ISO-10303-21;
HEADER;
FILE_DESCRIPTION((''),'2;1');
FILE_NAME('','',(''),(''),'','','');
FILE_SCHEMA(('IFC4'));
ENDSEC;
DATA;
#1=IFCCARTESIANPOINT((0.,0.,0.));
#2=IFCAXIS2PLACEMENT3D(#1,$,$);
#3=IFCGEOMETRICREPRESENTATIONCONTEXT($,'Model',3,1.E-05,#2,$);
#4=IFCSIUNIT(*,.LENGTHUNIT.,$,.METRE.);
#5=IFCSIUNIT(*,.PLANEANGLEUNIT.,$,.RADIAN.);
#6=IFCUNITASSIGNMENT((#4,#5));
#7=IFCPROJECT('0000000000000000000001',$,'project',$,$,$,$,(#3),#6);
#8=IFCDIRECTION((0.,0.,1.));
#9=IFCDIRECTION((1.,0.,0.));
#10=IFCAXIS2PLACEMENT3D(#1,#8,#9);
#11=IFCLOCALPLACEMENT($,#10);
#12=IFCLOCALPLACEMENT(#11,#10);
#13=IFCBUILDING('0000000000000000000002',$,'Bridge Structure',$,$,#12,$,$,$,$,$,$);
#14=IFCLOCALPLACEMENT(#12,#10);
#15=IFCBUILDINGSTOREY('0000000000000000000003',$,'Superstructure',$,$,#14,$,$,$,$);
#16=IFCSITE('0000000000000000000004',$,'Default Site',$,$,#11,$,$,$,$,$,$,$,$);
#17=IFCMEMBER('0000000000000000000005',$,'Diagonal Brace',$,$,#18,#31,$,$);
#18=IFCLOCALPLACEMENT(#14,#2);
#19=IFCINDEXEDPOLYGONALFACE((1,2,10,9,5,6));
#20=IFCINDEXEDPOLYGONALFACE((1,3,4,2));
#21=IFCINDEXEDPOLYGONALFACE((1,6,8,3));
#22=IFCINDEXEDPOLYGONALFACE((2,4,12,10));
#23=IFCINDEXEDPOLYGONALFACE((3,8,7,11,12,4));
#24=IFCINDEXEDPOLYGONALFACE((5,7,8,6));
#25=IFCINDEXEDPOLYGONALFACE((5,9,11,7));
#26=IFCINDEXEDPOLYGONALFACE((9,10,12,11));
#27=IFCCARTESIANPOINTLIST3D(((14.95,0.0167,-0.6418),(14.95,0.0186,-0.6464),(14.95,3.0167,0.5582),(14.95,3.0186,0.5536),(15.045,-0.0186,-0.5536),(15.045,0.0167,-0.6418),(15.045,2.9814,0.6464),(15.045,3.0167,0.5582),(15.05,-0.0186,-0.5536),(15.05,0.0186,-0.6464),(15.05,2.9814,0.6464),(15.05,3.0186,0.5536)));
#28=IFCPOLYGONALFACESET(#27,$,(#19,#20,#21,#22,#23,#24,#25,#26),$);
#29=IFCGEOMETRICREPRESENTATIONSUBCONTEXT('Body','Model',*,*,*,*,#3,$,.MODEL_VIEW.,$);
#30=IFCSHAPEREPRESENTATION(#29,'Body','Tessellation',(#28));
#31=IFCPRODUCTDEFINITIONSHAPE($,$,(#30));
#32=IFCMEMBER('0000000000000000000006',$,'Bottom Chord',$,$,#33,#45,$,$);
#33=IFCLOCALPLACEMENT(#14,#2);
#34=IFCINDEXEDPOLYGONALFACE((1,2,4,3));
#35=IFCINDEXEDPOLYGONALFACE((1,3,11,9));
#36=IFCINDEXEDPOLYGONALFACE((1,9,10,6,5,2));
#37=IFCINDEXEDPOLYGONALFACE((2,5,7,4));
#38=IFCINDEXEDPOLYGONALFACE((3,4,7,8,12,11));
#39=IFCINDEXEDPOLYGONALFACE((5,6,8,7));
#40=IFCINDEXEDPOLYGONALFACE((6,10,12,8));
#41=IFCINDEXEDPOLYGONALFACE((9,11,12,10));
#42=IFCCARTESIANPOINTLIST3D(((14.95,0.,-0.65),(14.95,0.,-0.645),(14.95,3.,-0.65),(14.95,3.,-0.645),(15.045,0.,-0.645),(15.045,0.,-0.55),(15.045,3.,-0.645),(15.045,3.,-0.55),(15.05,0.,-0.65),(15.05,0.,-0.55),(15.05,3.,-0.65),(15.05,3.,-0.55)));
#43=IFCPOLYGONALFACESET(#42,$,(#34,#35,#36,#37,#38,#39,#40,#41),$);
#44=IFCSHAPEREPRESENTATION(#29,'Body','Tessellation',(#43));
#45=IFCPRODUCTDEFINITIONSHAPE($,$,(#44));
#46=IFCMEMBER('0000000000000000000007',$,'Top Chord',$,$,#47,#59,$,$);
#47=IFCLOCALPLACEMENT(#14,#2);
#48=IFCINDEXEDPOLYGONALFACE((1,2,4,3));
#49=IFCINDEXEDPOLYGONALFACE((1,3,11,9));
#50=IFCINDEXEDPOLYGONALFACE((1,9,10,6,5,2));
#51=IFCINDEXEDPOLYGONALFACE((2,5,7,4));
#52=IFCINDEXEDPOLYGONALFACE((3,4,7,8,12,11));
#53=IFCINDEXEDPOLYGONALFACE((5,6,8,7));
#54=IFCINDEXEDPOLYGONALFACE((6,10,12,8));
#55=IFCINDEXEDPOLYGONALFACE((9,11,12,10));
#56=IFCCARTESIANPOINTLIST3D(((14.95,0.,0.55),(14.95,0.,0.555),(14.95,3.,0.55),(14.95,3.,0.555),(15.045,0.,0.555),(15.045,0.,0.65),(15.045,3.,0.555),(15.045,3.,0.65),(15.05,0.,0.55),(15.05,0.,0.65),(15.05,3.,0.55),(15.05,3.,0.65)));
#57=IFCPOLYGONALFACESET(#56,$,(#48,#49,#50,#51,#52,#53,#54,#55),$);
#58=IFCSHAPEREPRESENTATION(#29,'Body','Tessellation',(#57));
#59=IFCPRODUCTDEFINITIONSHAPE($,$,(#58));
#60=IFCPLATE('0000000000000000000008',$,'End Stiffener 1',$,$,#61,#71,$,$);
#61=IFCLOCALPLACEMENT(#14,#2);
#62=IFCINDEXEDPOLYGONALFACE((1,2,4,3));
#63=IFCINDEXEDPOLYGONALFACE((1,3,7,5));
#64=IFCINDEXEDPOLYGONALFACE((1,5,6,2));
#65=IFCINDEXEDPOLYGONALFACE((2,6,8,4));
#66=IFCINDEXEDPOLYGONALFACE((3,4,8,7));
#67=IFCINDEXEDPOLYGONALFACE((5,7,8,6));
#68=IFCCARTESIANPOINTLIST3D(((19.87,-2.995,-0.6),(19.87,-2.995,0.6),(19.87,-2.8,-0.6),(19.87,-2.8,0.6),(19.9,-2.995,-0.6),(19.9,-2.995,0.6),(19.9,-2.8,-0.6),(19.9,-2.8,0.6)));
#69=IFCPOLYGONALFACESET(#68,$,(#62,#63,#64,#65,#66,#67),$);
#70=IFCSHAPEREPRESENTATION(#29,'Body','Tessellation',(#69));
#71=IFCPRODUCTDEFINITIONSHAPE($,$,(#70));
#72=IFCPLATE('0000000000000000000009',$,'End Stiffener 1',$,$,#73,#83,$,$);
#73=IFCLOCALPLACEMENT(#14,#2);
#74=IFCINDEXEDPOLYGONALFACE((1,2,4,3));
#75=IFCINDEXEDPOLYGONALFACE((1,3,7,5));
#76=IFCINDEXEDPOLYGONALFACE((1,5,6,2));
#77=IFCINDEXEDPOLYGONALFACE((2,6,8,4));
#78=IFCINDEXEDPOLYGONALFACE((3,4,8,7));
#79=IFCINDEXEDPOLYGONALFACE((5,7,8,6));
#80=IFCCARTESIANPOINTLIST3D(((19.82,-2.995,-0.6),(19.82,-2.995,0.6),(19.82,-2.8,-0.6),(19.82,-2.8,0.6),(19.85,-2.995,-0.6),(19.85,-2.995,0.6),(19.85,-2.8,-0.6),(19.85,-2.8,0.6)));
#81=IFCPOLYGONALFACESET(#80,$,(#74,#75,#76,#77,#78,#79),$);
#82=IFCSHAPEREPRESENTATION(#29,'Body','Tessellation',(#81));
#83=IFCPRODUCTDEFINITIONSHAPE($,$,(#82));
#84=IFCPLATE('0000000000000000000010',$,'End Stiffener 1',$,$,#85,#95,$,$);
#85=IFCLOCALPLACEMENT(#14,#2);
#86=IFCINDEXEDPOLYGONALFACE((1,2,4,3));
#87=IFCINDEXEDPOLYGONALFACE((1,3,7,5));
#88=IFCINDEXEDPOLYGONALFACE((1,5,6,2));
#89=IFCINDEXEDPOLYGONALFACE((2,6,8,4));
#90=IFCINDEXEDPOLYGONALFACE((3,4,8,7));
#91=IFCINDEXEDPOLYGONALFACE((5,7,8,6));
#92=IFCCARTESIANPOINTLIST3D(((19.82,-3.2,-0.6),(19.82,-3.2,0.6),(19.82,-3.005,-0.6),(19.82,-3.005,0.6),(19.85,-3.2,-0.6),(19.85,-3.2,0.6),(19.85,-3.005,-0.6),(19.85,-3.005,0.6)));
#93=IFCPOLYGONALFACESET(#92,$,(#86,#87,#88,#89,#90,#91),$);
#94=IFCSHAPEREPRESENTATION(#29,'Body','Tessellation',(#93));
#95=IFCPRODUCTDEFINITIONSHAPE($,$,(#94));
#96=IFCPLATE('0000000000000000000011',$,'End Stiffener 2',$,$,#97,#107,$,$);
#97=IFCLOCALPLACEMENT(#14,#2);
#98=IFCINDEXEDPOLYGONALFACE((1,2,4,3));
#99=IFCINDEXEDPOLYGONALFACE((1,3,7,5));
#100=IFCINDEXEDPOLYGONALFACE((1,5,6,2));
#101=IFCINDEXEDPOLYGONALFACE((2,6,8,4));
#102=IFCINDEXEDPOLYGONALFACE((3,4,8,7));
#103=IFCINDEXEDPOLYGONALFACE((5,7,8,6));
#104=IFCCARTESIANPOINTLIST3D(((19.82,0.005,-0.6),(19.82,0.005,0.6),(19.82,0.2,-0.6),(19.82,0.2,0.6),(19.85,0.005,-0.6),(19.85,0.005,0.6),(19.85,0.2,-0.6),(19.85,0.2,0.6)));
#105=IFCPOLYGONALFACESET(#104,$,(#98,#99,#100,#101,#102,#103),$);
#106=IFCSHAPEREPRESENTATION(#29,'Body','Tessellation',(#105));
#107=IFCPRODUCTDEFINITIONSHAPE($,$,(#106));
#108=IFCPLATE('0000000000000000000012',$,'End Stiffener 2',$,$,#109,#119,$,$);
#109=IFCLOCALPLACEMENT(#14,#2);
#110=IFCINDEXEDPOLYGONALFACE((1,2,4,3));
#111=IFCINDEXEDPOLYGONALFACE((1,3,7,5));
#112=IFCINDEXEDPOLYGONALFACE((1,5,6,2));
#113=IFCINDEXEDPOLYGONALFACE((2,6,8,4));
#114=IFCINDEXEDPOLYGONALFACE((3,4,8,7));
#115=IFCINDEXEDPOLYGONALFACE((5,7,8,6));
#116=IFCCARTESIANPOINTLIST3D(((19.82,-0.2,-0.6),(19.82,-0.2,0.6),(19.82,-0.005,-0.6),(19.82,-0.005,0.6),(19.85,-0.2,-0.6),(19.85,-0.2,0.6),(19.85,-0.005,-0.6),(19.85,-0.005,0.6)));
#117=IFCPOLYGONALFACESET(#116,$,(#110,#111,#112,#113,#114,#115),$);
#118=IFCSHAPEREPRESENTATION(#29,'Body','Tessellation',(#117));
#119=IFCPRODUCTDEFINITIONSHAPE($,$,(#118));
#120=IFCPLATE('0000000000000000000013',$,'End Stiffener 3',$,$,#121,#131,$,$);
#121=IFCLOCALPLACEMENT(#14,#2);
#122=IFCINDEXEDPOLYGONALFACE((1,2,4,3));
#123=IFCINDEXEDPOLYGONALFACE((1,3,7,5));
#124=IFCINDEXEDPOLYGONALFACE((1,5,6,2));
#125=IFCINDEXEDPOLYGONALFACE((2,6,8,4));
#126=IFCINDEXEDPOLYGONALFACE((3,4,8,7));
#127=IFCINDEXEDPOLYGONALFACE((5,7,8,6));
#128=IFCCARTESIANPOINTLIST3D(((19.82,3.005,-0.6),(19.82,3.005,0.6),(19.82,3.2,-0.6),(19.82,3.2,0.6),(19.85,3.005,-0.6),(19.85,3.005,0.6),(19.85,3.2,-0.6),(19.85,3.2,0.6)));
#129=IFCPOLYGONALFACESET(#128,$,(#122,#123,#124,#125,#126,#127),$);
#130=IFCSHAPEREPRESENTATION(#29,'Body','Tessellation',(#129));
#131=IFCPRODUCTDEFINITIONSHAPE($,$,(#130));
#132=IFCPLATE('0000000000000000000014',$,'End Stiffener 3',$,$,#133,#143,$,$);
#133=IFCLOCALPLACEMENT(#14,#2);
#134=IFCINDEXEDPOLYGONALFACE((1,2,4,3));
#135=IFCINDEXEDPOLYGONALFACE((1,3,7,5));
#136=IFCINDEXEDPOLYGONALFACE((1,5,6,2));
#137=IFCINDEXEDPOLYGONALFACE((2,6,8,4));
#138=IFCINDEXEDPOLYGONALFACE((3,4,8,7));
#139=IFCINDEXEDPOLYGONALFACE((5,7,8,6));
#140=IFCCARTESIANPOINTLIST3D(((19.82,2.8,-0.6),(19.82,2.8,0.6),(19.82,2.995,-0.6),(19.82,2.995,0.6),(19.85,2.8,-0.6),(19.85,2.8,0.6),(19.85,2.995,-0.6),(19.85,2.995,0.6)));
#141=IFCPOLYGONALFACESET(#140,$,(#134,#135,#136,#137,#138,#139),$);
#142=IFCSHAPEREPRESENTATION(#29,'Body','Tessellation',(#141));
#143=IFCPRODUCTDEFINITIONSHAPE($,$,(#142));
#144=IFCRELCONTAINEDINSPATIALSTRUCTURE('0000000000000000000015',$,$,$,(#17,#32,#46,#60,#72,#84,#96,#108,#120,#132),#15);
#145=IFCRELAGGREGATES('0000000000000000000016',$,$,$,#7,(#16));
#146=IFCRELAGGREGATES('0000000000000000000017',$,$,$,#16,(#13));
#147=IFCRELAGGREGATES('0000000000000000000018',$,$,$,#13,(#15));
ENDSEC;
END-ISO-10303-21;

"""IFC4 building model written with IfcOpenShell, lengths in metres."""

from ifc_helpers import new_model, si_unit, frame, origin, origin_with_axes, origin_2d_with_axis, place, context, subcontext, project, spatial, rectangle, l_section, extrude, element, save


model = new_model("IFC4")

# Units and contexts
model_context = context("Model", 3, precision=1e-05, world=origin())
body_context = subcontext(model_context, "Body", "Model", "MODEL_VIEW")
ifc_project = project(units=[si_unit("LENGTHUNIT", "METRE"), si_unit("PLANEANGLEUNIT", "RADIAN")], contexts=[model_context])

# Site, building, storey
site_placement = place(None, origin_with_axes())
site = spatial("IfcSite", under=ifc_project, at=site_placement, Name="Default Site")
building_placement = place(site_placement, origin_with_axes())
building = spatial("IfcBuilding", under=site, at=building_placement, Name="Bridge Structure")
storey_placement = place(building_placement, origin_with_axes())
storey = spatial("IfcBuildingStorey", under=building, at=storey_placement, Name="Superstructure")

# Members
for number, where, z_axis, x_axis, name in (
    (1, (15.0, 0.0, -0.6), (0.0, 0.928477, 0.371391), (-1.0, 0.0, 0.0), "Diagonal Brace"),
):
    element("IfcMember", number, at=place(storey_placement, frame(where, z_axis=z_axis, x_axis=x_axis)), inside=storey, Name=name, context=body_context, shape_type="SweptSolid", body=[
        extrude(l_section(Depth=0.1, Width=0.1, Thickness=0.005, at=origin_2d_with_axis()), origin_with_axes(), (0.0, 0.0, 1.0), 3.2311),
    ])
for number, where, z_axis, x_axis, name in (
    (2, (15.0, 0.0, -0.6), (0.0, 1.0, 0.0), (-1.0, 0.0, 0.0), "Bottom Chord"),
    (3, (15.0, 0.0, 0.6), (0.0, 1.0, 0.0), (-1.0, 0.0, 0.0), "Top Chord"),
):
    element("IfcMember", number, at=place(storey_placement, frame(where, z_axis=z_axis, x_axis=x_axis)), inside=storey, Name=name, context=body_context, shape_type="SweptSolid", body=[
        extrude(l_section(Depth=0.1, Width=0.1, Thickness=0.005, at=origin_2d_with_axis()), origin_with_axes(), (0.0, 0.0, 1.0), 3.0),
    ])

# Plates
for number, where, z_axis, x_axis, name in (
    (4, (19.885, -2.8975, -0.6), (0.0, 0.0, 1.0), (1.0, 0.0, 0.0), "End Stiffener 1"),
    (5, (19.835, -2.8975, -0.6), (0.0, 0.0, 1.0), (1.0, 0.0, 0.0), "End Stiffener 1"),
    (6, (19.835, -3.1025, -0.6), (0.0, 0.0, 1.0), (1.0, 0.0, 0.0), "End Stiffener 1"),
    (7, (19.835, 0.1025, -0.6), (0.0, 0.0, 1.0), (1.0, 0.0, 0.0), "End Stiffener 2"),
    (8, (19.835, -0.1025, -0.6), (0.0, 0.0, 1.0), (1.0, 0.0, 0.0), "End Stiffener 2"),
    (9, (19.835, 3.1025, -0.6), (0.0, 0.0, 1.0), (1.0, 0.0, 0.0), "End Stiffener 3"),
    (10, (19.835, 2.8975, -0.6), (0.0, 0.0, 1.0), (1.0, 0.0, 0.0), "End Stiffener 3"),
):
    element("IfcPlate", number, at=place(storey_placement, frame(where, z_axis=z_axis, x_axis=x_axis)), inside=storey, Name=name, context=body_context, shape_type="SweptSolid", body=[
        extrude(rectangle(XDim=0.03, YDim=0.195, at=origin_2d_with_axis()), origin_with_axes(), (0.0, 0.0, 1.0), 1.2),
    ])

save(model, "model.ifc")
